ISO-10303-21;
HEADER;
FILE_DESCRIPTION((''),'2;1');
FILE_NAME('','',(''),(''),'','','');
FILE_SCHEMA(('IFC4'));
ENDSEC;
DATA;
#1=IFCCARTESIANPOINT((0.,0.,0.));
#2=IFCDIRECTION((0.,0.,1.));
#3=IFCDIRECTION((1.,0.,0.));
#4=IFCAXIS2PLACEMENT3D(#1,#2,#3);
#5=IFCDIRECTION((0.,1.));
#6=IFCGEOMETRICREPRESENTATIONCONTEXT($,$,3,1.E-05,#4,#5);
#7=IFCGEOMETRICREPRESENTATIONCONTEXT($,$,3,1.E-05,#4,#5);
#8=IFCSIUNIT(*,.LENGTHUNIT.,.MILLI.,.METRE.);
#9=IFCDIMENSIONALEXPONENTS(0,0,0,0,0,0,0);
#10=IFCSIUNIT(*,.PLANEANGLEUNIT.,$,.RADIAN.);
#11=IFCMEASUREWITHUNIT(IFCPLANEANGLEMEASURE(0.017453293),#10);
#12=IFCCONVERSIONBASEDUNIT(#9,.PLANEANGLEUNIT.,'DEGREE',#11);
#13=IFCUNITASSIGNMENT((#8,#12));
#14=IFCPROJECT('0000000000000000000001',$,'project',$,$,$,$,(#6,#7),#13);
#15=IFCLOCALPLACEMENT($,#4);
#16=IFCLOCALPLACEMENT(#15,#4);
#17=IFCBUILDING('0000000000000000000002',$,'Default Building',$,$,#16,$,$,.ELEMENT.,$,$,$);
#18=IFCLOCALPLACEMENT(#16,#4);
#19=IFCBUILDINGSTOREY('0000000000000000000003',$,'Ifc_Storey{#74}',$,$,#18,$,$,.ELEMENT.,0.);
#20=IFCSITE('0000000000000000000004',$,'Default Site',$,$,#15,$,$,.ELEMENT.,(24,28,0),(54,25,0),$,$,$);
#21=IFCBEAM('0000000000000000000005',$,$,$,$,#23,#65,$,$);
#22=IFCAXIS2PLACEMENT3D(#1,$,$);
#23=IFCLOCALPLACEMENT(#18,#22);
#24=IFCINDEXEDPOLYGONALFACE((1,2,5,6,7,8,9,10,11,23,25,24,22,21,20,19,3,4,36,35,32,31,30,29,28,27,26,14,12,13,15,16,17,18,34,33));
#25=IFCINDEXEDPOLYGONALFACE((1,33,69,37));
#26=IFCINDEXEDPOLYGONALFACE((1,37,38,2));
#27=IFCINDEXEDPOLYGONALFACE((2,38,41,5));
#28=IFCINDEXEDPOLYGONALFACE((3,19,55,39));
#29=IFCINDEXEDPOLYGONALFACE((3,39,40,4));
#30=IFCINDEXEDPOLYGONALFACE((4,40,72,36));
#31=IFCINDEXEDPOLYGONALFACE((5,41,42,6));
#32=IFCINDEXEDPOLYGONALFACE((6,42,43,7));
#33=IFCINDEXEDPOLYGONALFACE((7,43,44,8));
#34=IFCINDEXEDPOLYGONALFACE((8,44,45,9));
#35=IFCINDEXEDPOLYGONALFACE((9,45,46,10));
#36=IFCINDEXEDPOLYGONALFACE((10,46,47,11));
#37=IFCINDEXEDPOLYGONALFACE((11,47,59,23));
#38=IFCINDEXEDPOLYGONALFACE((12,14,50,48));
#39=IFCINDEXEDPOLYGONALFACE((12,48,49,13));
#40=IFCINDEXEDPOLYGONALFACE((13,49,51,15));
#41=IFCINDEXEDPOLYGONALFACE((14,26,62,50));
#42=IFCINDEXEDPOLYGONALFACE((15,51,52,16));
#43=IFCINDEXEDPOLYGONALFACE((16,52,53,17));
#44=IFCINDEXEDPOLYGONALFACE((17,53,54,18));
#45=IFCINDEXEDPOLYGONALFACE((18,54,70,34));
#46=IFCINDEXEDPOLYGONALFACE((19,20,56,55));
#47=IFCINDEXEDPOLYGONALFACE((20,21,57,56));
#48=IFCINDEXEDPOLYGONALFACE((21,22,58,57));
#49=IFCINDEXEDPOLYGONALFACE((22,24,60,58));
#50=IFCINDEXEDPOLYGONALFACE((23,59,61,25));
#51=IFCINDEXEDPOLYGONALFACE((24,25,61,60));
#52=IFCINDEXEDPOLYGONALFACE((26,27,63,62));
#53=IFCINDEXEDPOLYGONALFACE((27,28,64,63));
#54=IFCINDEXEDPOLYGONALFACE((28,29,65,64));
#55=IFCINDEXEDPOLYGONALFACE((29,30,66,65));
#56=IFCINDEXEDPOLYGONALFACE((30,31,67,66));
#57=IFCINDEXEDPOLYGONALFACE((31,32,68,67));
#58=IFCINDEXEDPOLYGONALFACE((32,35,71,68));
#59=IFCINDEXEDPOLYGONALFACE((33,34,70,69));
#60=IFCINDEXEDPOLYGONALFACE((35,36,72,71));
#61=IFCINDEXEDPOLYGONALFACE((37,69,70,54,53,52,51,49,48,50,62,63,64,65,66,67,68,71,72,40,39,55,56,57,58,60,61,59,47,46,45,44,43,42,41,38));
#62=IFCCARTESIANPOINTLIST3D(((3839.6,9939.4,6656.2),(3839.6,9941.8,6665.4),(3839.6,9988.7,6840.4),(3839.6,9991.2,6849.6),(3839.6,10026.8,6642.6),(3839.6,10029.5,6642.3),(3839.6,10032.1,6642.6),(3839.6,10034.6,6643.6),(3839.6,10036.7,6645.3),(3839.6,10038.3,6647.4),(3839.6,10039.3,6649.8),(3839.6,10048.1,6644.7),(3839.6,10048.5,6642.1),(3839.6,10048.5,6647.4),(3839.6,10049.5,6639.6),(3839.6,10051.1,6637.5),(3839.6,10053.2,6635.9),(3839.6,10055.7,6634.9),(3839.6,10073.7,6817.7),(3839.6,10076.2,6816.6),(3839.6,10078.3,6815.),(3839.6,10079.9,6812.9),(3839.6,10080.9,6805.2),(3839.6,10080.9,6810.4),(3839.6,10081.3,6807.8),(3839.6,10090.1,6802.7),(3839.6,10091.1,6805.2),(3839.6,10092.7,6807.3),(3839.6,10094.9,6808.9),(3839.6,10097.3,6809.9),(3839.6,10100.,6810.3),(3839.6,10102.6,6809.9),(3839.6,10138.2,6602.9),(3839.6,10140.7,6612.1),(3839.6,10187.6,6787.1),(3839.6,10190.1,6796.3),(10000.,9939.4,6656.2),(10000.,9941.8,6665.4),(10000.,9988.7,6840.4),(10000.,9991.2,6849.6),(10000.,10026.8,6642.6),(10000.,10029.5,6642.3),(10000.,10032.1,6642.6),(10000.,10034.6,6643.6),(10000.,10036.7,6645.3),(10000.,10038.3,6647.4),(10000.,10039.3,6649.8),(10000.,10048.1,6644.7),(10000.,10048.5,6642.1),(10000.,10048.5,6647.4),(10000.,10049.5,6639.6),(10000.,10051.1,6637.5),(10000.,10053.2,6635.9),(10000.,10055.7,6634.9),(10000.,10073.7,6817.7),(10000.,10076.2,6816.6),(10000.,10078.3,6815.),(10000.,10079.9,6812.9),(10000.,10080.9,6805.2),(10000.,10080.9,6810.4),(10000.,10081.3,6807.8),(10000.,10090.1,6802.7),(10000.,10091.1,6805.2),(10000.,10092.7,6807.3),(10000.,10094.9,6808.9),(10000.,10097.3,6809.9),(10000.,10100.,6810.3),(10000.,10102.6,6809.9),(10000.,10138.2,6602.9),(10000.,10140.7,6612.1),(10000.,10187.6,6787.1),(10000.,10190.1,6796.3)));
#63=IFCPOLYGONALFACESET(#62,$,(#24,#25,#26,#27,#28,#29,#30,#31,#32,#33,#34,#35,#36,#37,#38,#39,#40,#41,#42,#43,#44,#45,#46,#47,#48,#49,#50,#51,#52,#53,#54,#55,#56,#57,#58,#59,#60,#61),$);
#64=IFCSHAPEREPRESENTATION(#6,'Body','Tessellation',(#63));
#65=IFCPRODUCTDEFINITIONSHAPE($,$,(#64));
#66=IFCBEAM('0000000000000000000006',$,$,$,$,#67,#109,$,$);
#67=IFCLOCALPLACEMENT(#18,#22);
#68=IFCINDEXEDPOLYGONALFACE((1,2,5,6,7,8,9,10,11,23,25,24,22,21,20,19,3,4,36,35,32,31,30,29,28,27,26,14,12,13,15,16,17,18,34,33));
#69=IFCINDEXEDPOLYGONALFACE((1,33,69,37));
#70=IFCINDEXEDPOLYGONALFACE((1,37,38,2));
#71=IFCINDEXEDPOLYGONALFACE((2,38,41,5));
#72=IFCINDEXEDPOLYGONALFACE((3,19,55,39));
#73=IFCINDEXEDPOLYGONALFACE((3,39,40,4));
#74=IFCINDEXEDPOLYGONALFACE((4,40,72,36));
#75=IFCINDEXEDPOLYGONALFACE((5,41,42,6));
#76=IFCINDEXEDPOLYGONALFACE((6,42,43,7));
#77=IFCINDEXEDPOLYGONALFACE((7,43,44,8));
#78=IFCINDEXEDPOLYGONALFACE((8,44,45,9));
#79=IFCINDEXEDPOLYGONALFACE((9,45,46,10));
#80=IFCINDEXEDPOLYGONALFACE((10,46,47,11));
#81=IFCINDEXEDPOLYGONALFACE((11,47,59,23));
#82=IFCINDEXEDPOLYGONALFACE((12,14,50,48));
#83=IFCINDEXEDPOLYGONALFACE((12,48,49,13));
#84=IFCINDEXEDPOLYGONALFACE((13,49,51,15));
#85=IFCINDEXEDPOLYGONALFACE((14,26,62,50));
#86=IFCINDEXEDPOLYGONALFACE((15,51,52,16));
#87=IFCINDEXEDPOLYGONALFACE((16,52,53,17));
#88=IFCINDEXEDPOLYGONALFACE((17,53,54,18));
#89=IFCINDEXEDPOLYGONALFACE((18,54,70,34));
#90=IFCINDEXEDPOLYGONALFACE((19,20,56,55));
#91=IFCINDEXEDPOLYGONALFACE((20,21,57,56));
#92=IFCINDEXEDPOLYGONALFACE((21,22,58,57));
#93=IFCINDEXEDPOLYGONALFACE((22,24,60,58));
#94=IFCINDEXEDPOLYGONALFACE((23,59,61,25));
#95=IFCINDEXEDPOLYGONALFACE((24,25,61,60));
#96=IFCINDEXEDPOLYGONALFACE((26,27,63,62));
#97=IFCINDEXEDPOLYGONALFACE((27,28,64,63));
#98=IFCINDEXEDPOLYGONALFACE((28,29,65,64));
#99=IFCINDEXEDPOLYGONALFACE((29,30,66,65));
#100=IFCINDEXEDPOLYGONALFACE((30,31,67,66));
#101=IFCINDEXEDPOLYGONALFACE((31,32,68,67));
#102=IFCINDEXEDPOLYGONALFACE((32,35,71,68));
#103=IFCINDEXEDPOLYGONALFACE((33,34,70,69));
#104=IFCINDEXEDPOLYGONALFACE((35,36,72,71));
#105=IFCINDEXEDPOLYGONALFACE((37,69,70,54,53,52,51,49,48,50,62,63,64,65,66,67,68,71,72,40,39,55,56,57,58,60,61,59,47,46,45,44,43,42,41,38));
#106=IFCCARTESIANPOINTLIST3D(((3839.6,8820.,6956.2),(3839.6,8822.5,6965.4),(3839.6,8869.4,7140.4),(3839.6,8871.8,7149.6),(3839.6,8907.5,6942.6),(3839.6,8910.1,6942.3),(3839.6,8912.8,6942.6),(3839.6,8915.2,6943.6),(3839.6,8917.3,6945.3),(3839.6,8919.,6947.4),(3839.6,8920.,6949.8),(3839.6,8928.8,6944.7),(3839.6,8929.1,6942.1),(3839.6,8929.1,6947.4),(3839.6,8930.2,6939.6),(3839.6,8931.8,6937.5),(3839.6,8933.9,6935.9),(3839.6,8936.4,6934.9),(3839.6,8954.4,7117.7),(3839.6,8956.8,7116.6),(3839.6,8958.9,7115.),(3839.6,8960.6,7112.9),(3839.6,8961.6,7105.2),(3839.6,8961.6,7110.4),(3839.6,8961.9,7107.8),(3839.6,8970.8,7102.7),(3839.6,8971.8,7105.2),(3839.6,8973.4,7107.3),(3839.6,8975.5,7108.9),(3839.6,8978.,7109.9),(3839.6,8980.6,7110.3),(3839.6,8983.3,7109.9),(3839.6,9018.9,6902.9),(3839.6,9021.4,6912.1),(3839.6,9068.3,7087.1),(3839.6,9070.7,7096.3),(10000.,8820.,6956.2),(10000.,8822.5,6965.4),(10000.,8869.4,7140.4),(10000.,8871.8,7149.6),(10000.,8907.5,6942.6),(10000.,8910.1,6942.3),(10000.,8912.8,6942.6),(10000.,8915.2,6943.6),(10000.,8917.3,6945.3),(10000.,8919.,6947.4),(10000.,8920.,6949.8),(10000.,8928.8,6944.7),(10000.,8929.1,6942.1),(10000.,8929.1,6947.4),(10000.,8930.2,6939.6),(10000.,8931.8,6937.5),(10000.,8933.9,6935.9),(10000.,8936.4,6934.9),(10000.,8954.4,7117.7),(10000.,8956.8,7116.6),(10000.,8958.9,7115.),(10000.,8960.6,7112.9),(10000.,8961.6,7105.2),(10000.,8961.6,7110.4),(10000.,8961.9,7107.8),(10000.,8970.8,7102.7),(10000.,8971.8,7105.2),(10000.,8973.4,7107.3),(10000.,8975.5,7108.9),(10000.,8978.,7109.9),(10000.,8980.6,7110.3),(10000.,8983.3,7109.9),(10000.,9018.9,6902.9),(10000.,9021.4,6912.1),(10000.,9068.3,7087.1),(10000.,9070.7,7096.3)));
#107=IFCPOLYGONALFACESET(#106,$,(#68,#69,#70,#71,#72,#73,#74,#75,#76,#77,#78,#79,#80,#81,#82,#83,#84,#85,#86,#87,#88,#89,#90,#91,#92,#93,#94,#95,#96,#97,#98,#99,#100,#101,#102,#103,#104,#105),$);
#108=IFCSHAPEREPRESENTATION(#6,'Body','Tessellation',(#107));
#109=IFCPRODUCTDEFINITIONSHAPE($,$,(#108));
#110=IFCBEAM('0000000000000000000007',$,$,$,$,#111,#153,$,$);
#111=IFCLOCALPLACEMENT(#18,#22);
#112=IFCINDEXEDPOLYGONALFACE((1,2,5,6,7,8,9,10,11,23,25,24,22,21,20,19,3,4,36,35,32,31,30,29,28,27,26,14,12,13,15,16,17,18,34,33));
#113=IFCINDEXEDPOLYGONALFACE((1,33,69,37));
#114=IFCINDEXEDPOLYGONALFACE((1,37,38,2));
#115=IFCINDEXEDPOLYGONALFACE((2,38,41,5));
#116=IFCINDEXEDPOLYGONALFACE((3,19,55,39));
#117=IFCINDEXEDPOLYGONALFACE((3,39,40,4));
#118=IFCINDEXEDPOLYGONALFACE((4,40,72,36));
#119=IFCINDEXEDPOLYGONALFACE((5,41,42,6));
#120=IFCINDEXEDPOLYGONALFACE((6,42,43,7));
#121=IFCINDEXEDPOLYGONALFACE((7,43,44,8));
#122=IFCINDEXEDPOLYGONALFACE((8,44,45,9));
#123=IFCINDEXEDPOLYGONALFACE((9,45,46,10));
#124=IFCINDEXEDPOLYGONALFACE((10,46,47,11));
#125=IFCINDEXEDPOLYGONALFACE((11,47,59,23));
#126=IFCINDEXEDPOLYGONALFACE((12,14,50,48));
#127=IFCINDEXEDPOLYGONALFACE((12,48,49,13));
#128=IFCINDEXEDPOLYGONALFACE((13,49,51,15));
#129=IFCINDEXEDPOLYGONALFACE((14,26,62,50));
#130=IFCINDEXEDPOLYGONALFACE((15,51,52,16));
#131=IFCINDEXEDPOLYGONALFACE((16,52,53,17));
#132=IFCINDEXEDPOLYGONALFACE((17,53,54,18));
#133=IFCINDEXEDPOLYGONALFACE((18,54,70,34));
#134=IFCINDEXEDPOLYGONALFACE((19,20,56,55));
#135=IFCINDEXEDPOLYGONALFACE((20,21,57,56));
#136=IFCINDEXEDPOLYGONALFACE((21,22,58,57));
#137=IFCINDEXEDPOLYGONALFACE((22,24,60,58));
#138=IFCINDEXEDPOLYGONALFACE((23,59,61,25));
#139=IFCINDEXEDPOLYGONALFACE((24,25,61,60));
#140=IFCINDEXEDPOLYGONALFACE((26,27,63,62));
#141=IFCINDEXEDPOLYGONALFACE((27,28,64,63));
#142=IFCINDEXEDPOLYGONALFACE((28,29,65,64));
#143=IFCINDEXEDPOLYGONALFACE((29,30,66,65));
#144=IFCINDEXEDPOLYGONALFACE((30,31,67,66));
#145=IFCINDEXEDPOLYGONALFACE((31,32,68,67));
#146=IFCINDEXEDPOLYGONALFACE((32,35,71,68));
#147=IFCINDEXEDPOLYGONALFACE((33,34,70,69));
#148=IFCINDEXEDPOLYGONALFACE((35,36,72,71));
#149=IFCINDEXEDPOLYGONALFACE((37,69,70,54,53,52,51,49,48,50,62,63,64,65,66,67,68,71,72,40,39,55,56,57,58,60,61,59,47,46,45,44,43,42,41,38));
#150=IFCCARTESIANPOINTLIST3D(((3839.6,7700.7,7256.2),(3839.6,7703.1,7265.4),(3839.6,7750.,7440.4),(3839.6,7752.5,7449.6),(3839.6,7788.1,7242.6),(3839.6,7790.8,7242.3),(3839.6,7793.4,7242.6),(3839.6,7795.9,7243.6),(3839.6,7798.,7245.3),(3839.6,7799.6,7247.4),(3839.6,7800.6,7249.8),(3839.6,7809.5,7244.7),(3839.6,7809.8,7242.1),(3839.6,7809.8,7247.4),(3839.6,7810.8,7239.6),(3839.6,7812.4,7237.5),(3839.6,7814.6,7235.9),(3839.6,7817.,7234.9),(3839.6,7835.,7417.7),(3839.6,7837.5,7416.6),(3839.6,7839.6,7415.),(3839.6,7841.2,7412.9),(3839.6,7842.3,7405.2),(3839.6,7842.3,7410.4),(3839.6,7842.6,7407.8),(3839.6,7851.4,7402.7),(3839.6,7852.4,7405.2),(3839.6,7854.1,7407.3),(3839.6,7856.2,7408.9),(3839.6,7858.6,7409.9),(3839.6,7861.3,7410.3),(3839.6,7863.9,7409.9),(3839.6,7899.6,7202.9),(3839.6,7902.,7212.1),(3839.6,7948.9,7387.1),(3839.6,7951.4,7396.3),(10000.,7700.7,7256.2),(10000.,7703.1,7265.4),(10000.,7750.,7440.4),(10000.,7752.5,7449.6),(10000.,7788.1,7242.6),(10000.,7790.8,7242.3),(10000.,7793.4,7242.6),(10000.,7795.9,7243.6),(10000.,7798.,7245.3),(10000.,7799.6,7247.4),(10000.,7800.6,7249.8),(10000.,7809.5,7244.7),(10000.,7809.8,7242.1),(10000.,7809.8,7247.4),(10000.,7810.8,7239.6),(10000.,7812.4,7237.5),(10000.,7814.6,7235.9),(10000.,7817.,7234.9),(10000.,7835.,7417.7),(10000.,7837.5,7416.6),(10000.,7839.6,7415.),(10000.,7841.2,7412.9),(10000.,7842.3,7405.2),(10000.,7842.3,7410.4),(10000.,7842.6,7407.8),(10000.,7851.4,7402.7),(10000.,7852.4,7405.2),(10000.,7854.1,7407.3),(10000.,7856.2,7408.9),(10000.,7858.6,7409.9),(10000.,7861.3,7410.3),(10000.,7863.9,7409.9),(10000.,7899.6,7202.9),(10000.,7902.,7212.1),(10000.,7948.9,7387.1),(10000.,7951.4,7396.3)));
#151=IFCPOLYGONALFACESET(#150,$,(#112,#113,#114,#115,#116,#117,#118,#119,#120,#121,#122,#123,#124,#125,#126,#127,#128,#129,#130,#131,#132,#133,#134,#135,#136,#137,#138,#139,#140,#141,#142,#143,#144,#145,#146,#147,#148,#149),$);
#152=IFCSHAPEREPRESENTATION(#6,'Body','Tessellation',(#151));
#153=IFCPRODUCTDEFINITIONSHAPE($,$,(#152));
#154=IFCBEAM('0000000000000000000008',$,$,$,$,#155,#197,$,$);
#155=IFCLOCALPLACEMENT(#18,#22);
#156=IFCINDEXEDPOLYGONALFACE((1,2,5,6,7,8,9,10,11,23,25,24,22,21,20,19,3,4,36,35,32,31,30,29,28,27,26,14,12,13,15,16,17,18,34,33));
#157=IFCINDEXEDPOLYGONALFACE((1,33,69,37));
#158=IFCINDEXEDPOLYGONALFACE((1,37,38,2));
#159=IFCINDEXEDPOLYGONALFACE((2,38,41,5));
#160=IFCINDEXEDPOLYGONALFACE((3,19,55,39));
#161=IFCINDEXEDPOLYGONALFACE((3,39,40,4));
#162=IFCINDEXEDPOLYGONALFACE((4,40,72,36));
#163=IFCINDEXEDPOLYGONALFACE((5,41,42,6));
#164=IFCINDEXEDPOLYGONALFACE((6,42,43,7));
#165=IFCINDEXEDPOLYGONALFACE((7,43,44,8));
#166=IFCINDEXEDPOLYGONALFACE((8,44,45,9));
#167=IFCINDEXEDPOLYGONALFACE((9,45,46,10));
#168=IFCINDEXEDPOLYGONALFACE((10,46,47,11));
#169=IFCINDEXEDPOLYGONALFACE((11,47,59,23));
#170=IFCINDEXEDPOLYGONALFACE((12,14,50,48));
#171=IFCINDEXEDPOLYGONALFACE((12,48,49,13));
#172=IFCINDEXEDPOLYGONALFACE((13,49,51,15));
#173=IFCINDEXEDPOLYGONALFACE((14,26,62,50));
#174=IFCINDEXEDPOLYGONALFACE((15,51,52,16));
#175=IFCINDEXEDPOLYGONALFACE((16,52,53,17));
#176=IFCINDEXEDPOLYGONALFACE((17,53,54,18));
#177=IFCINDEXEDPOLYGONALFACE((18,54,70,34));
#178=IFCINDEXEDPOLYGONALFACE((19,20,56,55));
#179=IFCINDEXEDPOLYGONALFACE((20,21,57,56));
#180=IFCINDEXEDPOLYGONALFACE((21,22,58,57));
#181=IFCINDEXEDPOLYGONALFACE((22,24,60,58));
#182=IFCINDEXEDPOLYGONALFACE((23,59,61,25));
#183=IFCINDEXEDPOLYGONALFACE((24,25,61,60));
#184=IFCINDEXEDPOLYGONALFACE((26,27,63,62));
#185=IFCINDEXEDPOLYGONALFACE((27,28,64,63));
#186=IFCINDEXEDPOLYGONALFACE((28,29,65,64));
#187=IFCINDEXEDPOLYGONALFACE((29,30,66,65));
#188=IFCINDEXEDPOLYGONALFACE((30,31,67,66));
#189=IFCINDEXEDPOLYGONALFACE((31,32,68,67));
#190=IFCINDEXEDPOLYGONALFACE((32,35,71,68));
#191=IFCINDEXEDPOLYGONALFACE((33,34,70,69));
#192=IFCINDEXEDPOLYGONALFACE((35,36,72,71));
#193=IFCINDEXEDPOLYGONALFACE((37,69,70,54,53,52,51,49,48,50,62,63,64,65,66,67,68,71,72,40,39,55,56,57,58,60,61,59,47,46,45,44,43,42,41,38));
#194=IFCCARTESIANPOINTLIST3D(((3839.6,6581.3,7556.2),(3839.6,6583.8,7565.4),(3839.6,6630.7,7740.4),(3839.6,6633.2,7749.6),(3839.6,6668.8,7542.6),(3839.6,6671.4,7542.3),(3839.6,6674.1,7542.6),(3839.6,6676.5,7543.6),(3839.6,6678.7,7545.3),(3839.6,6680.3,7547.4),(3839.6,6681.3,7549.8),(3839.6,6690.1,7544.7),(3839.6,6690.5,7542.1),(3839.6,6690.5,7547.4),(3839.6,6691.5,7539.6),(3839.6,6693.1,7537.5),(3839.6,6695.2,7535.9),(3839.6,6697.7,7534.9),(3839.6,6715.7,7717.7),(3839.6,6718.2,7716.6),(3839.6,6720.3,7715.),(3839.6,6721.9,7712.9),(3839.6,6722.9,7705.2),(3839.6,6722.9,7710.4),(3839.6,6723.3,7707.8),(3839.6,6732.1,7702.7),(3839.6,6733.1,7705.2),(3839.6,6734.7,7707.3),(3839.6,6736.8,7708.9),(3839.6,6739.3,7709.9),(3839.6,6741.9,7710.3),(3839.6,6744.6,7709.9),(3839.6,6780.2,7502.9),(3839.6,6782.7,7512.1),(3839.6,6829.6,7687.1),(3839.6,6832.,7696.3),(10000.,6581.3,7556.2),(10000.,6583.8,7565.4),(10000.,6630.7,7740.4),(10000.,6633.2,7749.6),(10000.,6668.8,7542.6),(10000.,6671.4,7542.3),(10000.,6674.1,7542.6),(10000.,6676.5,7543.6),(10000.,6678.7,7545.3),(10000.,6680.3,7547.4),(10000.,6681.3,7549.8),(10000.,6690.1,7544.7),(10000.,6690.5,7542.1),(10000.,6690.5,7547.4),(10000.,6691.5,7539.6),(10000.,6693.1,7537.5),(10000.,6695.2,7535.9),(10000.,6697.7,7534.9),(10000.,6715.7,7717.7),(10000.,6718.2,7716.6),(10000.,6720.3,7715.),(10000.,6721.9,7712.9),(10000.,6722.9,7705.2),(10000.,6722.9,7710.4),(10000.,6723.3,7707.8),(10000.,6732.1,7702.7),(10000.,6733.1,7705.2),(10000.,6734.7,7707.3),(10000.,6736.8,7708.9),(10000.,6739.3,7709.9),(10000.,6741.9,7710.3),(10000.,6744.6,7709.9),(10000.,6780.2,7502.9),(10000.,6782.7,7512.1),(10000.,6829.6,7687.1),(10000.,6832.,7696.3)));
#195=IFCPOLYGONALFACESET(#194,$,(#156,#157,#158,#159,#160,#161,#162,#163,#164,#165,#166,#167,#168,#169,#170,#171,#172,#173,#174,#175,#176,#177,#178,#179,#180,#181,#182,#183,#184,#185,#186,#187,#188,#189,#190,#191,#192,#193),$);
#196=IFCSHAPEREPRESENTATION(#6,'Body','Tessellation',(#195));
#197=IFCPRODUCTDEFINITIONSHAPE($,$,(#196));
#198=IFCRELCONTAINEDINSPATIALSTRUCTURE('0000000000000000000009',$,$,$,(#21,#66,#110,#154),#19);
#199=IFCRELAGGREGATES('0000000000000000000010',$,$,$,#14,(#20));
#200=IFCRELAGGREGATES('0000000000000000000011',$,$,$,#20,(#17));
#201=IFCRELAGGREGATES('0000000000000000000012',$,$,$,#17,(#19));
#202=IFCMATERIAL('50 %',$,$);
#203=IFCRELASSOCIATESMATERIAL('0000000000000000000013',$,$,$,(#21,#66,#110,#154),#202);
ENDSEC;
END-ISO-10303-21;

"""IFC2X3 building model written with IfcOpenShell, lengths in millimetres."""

from ifc_helpers import new_model, entity, si_unit, converted_unit, direction, frame, origin_with_axes, origin_2d_with_axis, place, context, project, spatial, i_section, extrude, material, element, save


model = new_model("IFC2X3")

# Units and contexts
context_of_model_1 = context(None, 3, precision=1e-05, world=origin_with_axes(), true_north=direction((0.0, 1.0)))
context_of_model_2 = context(None, 3, precision=1e-05, world=origin_with_axes(), true_north=direction((0.0, 1.0)))
ifc_project = project(units=[si_unit("LENGTHUNIT", "METRE", prefix="MILLI"), converted_unit("PLANEANGLEUNIT", "DEGREE", entity("IfcPlaneAngleMeasure", 0.017453293), si_unit("PLANEANGLEUNIT", "RADIAN"), dimensions=[0, 0, 0, 0, 0, 0, 0])], contexts=[context_of_model_1, context_of_model_2])

# Site, building, storey
site_placement = place(None, origin_with_axes())
site = spatial("IfcSite", under=ifc_project, at=site_placement, Name="Default Site", CompositionType="ELEMENT", RefLatitude=(24, 28, 0), RefLongitude=(54, 25, 0))
building_placement = place(site_placement, origin_with_axes())
building = spatial("IfcBuilding", under=site, at=building_placement, Name="Default Building", CompositionType="ELEMENT")
storey_placement = place(building_placement, origin_with_axes())
storey = spatial("IfcBuildingStorey", under=building, at=storey_placement, Name="Ifc_Storey{#74}", CompositionType="ELEMENT", Elevation=0.0)

# Shared definitions
ifc_material_1 = material(Name="50 %")

# Beams
for number, where, z_axis, x_axis in (
    (1, (3839.6, 10064.7, 6726.3), (0.0, 0.258819, 0.965926), (1.0, 0.0, 0.0)),
    (2, (3839.6, 8945.4, 7026.3), (0.0, 0.258819, 0.965926), (1.0, 0.0, 0.0)),
    (3, (3839.6, 7826.0, 7326.3), (0.0, 0.258819, 0.965926), (1.0, 0.0, 0.0)),
    (4, (3839.6, 6706.7, 7626.3), (0.0, 0.258819, 0.965926), (1.0, 0.0, 0.0)),
):
    element("IfcBeam", number, at=place(storey_placement, frame(where, z_axis=z_axis, x_axis=x_axis)), inside=storey, material=ifc_material_1, context=context_of_model_1, shape_type="SweptSolid", body=[
        extrude(i_section(OverallWidth=205.9, OverallDepth=200.2, WebThickness=9.5, FlangeThickness=9.5, FilletRadius=10.2, at=origin_2d_with_axis()), frame((0.0, 0.0, 0.0), z_axis=(1.0, 0.0, 0.0), x_axis=(0.0, 1.0, 0.0)), (0.0, 0.0, 1.0), 6160.4),
    ])

save(model, "model.ifc")
